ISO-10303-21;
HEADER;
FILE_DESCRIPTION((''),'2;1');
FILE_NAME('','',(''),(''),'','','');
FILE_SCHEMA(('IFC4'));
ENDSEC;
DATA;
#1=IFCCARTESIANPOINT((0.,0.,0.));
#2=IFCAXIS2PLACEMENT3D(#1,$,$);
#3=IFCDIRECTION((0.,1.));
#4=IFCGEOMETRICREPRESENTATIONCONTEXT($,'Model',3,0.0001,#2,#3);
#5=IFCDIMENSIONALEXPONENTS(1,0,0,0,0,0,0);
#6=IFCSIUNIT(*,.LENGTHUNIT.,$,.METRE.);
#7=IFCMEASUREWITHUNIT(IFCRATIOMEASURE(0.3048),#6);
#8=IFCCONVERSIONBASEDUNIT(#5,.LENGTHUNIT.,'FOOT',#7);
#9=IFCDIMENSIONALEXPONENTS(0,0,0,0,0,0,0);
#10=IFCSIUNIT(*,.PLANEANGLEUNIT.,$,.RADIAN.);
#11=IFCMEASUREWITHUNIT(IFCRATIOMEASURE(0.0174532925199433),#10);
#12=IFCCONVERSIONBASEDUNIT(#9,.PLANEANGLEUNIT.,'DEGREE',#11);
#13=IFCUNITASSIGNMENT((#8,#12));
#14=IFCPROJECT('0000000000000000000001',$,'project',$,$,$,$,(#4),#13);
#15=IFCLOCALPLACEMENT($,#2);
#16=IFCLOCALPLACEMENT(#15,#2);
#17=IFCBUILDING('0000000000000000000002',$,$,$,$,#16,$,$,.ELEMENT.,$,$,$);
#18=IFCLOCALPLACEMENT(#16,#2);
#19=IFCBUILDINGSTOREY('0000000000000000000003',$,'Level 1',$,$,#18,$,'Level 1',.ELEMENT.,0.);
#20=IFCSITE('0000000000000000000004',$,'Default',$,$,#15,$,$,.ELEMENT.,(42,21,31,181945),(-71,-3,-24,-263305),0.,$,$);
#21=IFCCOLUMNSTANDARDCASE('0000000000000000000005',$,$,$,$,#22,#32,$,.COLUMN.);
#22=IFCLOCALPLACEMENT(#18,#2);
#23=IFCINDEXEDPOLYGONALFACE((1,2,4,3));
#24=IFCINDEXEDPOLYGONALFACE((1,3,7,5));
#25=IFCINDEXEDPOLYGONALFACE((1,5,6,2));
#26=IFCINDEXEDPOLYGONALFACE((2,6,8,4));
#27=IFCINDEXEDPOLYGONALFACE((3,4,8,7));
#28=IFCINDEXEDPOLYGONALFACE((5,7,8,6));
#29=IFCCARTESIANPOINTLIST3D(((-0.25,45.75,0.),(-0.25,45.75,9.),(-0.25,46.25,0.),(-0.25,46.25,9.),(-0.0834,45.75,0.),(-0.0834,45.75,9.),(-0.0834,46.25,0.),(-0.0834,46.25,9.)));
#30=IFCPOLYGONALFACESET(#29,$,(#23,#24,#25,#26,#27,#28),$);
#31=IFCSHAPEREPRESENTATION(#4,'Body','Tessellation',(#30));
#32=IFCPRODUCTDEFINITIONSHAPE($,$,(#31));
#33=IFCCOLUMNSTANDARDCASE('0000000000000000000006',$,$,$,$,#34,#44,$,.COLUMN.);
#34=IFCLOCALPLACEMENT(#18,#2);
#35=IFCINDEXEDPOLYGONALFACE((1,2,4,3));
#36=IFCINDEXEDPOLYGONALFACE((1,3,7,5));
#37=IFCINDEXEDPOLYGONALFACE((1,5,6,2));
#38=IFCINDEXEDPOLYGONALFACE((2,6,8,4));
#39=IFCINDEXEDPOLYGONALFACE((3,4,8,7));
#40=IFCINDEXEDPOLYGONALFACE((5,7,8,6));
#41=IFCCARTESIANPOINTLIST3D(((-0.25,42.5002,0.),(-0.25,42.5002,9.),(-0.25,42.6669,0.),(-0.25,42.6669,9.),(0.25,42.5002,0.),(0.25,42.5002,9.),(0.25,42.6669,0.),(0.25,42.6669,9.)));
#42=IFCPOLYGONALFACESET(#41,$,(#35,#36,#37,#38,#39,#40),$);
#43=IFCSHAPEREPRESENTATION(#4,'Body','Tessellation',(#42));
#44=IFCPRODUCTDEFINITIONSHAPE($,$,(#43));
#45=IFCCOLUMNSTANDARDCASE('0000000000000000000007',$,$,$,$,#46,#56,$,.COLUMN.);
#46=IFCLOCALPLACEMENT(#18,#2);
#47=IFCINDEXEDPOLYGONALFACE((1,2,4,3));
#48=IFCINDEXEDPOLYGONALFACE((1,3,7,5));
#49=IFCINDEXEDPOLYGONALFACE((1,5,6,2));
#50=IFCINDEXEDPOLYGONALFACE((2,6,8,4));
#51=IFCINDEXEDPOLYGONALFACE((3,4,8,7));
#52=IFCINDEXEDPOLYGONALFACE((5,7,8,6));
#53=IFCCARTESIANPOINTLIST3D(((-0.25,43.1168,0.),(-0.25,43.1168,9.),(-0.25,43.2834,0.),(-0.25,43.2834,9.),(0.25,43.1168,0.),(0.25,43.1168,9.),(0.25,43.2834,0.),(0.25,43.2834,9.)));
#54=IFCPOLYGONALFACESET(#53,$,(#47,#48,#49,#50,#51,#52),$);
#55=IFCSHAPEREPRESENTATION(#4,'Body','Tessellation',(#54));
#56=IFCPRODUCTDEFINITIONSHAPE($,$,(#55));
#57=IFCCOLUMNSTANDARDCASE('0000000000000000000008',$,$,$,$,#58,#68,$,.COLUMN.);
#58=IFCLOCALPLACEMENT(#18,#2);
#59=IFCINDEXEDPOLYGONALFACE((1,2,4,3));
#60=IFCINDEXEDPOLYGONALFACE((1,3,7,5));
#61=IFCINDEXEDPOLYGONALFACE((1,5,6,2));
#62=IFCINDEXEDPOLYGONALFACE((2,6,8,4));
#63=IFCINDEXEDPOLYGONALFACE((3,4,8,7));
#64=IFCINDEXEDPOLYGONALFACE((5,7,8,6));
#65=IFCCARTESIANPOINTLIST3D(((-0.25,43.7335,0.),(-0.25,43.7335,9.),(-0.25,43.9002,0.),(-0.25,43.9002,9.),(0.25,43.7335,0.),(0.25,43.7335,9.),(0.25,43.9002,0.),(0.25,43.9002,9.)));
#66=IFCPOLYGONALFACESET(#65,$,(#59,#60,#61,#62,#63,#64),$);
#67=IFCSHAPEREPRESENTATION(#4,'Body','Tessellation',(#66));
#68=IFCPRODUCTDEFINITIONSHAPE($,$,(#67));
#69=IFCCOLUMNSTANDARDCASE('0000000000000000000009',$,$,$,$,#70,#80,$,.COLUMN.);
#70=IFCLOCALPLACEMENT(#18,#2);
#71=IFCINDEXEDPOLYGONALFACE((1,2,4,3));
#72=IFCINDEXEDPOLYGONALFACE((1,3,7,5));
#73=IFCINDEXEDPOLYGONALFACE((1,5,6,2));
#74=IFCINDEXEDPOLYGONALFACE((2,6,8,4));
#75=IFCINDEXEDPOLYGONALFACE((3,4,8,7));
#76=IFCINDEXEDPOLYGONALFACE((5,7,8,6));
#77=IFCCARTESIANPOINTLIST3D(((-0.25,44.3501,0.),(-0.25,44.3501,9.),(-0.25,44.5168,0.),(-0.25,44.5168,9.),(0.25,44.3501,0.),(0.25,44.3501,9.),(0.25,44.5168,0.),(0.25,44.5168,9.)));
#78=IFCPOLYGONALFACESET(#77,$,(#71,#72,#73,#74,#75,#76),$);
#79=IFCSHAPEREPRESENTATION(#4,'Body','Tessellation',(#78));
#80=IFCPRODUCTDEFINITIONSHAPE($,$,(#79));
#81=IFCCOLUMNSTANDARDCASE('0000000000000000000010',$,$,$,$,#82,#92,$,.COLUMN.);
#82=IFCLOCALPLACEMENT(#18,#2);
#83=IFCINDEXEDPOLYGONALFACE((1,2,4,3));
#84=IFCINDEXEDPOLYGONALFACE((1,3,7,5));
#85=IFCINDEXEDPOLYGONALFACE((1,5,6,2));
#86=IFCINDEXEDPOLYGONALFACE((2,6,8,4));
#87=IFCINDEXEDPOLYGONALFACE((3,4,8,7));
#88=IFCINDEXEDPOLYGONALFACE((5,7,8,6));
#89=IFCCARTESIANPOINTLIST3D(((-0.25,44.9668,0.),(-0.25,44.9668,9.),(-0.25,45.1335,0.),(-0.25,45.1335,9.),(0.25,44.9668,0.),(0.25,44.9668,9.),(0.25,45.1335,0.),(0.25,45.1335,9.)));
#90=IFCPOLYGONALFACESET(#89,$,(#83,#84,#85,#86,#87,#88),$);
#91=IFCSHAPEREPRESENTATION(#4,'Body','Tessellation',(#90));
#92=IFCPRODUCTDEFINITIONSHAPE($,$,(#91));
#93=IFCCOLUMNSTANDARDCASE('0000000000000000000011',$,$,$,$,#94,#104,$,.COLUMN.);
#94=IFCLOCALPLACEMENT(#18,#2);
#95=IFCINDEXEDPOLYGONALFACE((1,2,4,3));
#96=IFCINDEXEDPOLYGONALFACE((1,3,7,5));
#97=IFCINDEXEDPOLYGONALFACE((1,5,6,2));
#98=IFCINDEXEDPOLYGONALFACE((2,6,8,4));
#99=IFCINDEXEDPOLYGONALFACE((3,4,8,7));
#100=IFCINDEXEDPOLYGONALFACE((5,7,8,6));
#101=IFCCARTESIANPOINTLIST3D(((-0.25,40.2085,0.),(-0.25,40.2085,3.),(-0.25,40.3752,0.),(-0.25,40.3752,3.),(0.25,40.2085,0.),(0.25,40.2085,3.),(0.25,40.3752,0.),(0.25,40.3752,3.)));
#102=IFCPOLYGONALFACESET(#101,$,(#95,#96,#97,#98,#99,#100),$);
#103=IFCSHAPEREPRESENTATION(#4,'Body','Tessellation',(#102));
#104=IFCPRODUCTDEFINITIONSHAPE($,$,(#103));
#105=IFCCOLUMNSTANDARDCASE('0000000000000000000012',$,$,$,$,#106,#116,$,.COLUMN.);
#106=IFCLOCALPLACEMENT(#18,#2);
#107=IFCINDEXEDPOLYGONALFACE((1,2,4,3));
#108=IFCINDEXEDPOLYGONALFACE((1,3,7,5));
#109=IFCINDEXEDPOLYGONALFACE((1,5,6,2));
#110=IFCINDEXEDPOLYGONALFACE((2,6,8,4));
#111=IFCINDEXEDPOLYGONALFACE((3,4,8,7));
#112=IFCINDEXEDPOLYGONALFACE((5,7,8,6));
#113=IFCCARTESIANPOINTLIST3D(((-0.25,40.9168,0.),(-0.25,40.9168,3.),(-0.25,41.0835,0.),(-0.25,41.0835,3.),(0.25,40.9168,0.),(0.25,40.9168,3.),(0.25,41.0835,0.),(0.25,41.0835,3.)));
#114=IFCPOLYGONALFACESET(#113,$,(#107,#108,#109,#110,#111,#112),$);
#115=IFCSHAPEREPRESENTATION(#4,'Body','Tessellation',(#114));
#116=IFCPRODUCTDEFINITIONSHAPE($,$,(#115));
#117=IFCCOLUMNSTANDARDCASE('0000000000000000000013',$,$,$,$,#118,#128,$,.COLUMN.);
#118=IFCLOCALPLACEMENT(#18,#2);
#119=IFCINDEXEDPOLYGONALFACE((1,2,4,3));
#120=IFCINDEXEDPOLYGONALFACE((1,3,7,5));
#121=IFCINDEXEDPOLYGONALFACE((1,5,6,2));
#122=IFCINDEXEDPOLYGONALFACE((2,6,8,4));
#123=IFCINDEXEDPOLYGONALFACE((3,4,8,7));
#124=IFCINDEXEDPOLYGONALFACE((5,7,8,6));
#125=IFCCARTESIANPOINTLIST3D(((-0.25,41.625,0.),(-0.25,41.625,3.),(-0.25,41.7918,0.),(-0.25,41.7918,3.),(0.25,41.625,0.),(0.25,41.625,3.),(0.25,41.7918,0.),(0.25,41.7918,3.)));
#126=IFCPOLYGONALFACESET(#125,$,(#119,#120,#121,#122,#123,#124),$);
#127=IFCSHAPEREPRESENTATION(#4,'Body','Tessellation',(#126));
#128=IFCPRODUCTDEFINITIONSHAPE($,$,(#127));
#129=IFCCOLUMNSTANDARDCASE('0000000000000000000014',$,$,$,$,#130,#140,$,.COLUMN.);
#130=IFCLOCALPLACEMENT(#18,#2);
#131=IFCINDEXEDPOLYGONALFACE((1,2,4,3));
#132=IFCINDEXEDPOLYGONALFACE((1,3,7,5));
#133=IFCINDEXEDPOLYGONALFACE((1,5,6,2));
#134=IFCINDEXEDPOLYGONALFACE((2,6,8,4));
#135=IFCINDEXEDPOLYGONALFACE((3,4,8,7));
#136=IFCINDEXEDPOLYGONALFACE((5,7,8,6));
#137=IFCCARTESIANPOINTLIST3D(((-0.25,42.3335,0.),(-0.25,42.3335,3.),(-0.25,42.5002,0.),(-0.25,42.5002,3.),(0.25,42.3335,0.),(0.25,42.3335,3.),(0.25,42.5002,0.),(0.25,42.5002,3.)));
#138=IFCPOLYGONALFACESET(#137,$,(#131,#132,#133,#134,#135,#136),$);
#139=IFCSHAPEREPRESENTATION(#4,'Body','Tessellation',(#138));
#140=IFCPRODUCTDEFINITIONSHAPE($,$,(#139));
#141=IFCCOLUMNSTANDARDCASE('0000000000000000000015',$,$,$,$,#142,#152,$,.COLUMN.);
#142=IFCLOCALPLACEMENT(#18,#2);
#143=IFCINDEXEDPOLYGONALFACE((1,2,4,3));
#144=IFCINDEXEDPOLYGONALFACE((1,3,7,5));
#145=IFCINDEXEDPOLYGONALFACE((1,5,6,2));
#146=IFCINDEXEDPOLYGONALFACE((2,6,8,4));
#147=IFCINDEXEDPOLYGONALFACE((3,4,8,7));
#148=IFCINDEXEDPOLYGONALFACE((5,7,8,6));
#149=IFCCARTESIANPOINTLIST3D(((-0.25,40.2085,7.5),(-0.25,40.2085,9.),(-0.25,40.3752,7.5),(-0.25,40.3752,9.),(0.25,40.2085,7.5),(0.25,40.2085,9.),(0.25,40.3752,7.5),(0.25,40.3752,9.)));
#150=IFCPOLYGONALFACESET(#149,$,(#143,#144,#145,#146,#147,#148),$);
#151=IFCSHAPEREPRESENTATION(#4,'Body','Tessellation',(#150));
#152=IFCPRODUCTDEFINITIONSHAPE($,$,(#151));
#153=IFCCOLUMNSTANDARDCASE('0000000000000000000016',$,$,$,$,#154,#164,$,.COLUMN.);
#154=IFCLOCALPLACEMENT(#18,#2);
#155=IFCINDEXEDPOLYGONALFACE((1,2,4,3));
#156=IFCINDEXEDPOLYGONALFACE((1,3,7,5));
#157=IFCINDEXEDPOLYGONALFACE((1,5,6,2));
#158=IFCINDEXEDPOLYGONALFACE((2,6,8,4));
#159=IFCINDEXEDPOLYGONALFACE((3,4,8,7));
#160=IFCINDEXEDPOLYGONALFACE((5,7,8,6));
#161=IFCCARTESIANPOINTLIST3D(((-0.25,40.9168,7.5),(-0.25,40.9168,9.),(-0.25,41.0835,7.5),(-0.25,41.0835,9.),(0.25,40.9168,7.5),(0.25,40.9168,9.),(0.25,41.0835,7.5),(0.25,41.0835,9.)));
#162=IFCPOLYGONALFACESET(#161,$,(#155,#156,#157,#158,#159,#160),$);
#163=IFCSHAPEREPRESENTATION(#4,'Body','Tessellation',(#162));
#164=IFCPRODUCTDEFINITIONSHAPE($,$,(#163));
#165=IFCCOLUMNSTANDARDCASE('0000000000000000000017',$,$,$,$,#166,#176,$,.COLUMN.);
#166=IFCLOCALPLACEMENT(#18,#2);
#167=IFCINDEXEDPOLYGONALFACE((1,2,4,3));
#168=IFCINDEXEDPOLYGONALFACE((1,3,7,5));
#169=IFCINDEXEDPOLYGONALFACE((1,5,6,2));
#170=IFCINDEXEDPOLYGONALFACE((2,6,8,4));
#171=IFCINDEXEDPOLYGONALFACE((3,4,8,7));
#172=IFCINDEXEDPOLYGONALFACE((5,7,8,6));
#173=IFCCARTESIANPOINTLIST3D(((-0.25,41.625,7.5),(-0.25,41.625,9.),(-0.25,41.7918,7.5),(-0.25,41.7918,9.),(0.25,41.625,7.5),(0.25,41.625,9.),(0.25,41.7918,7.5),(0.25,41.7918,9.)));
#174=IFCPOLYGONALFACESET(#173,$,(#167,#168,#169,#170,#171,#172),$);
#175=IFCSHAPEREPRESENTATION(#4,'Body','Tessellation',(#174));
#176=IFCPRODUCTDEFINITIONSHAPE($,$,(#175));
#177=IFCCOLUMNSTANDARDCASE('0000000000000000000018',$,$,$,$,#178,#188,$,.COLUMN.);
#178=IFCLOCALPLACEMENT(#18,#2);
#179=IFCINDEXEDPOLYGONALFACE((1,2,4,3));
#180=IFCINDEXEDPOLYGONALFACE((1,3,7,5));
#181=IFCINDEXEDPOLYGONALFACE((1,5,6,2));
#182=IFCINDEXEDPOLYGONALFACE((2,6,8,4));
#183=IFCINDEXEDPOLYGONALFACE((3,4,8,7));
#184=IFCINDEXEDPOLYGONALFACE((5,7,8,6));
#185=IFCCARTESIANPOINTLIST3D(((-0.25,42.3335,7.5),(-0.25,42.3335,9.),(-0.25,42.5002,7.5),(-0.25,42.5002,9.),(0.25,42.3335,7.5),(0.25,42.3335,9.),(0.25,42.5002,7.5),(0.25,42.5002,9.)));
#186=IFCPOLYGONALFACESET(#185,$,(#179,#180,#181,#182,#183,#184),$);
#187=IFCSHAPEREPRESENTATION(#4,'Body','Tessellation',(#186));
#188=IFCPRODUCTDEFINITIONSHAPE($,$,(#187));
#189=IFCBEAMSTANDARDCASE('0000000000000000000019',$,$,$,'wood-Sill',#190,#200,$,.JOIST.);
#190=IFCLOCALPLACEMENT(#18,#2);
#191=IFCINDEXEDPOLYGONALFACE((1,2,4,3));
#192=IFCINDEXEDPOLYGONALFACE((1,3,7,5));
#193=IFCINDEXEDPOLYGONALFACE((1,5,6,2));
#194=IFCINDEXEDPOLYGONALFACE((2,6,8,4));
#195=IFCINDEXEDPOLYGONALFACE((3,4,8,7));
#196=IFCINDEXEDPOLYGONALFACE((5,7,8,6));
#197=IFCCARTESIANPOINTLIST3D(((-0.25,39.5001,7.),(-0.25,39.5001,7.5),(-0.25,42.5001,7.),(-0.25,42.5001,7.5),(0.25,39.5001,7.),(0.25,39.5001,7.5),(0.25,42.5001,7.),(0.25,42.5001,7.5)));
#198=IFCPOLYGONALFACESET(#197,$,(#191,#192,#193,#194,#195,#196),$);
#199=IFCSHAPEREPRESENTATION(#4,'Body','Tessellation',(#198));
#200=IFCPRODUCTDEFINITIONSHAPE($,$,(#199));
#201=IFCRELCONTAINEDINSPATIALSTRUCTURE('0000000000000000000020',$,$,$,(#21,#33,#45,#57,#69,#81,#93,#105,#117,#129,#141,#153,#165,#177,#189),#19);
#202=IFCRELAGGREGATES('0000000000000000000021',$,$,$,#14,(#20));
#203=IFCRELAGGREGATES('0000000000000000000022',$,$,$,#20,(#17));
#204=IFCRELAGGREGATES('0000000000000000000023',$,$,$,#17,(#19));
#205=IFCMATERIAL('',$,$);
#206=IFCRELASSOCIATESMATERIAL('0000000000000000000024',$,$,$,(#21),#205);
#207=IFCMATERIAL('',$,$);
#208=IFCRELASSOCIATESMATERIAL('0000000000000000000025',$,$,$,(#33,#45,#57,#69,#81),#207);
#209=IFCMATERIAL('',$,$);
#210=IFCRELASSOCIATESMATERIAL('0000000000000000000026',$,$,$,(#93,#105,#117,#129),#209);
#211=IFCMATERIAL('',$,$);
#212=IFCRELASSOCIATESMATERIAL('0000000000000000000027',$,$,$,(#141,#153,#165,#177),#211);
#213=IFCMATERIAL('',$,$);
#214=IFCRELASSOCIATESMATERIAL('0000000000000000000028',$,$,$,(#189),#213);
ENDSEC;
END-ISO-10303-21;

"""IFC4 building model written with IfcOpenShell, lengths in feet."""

from ifc_helpers import new_model, entity, si_unit, converted_unit, direction, frame, origin, place, context, project, spatial, rectangle, extrude, material, element, save


model = new_model("IFC4")

# Units and contexts
model_context = context("Model", 3, precision=0.0001, world=origin(), true_north=direction((0.0, 1.0)))
ifc_project = project(units=[converted_unit("LENGTHUNIT", "FOOT", entity("IfcRatioMeasure", 0.3048), si_unit("LENGTHUNIT", "METRE"), dimensions=[1, 0, 0, 0, 0, 0, 0]), converted_unit("PLANEANGLEUNIT", "DEGREE", entity("IfcRatioMeasure", 0.0174532925199433), si_unit("PLANEANGLEUNIT", "RADIAN"), dimensions=[0, 0, 0, 0, 0, 0, 0])], contexts=[model_context])

# Site, building, storey
site_placement = place(None, origin())
site = spatial("IfcSite", under=ifc_project, at=site_placement, Name="Default", CompositionType="ELEMENT", RefLatitude=(42, 21, 31, 181945), RefLongitude=(-71, -3, -24, -263305), RefElevation=0.0)
building_placement = place(site_placement, origin())
building = spatial("IfcBuilding", under=site, at=building_placement, CompositionType="ELEMENT")
storey_placement = place(building_placement, origin())
storey = spatial("IfcBuildingStorey", under=building, at=storey_placement, Name="Level 1", LongName="Level 1", CompositionType="ELEMENT", Elevation=0.0)

# Columns
ifc_material_1 = material(Name="")
placement_1 = place(storey_placement, frame((-0.25, 46.0, 0.0)))
column_placement = place(placement_1, frame((0.0833, 0.0, 0.0), z_axis=(0.0, 0.0, 1.0), x_axis=(1.0, 0.0, 0.0)))
element("IfcColumnStandardCase", 1, at=column_placement, inside=storey, material=ifc_material_1, PredefinedType="COLUMN", context=model_context, shape_type="SweptSolid", body=[
    extrude(rectangle(XDim=0.1667, YDim=0.5), origin(), (0.0, 0.0, 1.0), 9.0),
])
ifc_material_2 = material(Name="")
placement_2 = place(storey_placement, frame((0.0, -0.25, 0.0), z_axis=(0.0, 0.0, 1.0), x_axis=(0.0, 1.0, 0.0)))
for number, where, z_axis, x_axis in (
    (2, (42.8335, 0.0, 0.0), (0.0, 0.0, 1.0), (1.0, 0.0, 0.0)),
    (3, (43.4501, 0.0, 0.0), (0.0, 0.0, 1.0), (1.0, 0.0, 0.0)),
    (4, (44.0668, 0.0, 0.0), (0.0, 0.0, 1.0), (1.0, 0.0, 0.0)),
    (5, (44.6834, 0.0, 0.0), (0.0, 0.0, 1.0), (1.0, 0.0, 0.0)),
    (6, (45.3001, 0.0, 0.0), (0.0, 0.0, 1.0), (1.0, 0.0, 0.0)),
):
    element("IfcColumnStandardCase", number, at=place(placement_2, frame(where, z_axis=z_axis, x_axis=x_axis)), inside=storey, material=ifc_material_2, PredefinedType="COLUMN", context=model_context, shape_type="SweptSolid", body=[
        extrude(rectangle(XDim=0.1667, YDim=0.5), origin(), (0.0, 0.0, 1.0), 9.0),
    ])
ifc_material_3 = material(Name="")
for number, where, z_axis, x_axis in (
    (7, (40.5418, 0.0, 0.0), (0.0, 0.0, 1.0), (1.0, 0.0, 0.0)),
    (8, (41.2501, 0.0, 0.0), (0.0, 0.0, 1.0), (1.0, 0.0, 0.0)),
    (9, (41.9584, 0.0, 0.0), (0.0, 0.0, 1.0), (1.0, 0.0, 0.0)),
    (10, (42.6668, 0.0, 0.0), (0.0, 0.0, 1.0), (1.0, 0.0, 0.0)),
):
    element("IfcColumnStandardCase", number, at=place(placement_2, frame(where, z_axis=z_axis, x_axis=x_axis)), inside=storey, material=ifc_material_3, PredefinedType="COLUMN", context=model_context, shape_type="SweptSolid", body=[
        extrude(rectangle(XDim=0.1667, YDim=0.5), origin(), (0.0, 0.0, 1.0), 3.0),
    ])
ifc_material_4 = material(Name="")
for number, where, z_axis, x_axis in (
    (11, (40.5418, 0.0, 7.5), (0.0, 0.0, 1.0), (1.0, 0.0, 0.0)),
    (12, (41.2501, 0.0, 7.5), (0.0, 0.0, 1.0), (1.0, 0.0, 0.0)),
    (13, (41.9584, 0.0, 7.5), (0.0, 0.0, 1.0), (1.0, 0.0, 0.0)),
    (14, (42.6668, 0.0, 7.5), (0.0, 0.0, 1.0), (1.0, 0.0, 0.0)),
):
    element("IfcColumnStandardCase", number, at=place(placement_2, frame(where, z_axis=z_axis, x_axis=x_axis)), inside=storey, material=ifc_material_4, PredefinedType="COLUMN", context=model_context, shape_type="SweptSolid", body=[
        extrude(rectangle(XDim=0.1667, YDim=0.5), origin(), (0.0, 0.0, 1.0), 1.5),
    ])

# Beam
ifc_material_5 = material(Name="")
for number, where, z_axis, x_axis in (
    (15, (41.2501, 0.0, 7.0), (0.0, 0.0, 1.0), (1.0, 0.0, 0.0)),
):
    element("IfcBeamStandardCase", number, at=place(placement_2, frame(where, z_axis=z_axis, x_axis=x_axis)), inside=storey, material=ifc_material_5, ObjectType="wood-Sill", PredefinedType="JOIST", context=model_context, shape_type="SweptSolid", body=[
        extrude(rectangle(XDim=3.0, YDim=0.5), origin(), (0.0, 0.0, 1.0), 0.5),
    ])

save(model, "model.ifc")
